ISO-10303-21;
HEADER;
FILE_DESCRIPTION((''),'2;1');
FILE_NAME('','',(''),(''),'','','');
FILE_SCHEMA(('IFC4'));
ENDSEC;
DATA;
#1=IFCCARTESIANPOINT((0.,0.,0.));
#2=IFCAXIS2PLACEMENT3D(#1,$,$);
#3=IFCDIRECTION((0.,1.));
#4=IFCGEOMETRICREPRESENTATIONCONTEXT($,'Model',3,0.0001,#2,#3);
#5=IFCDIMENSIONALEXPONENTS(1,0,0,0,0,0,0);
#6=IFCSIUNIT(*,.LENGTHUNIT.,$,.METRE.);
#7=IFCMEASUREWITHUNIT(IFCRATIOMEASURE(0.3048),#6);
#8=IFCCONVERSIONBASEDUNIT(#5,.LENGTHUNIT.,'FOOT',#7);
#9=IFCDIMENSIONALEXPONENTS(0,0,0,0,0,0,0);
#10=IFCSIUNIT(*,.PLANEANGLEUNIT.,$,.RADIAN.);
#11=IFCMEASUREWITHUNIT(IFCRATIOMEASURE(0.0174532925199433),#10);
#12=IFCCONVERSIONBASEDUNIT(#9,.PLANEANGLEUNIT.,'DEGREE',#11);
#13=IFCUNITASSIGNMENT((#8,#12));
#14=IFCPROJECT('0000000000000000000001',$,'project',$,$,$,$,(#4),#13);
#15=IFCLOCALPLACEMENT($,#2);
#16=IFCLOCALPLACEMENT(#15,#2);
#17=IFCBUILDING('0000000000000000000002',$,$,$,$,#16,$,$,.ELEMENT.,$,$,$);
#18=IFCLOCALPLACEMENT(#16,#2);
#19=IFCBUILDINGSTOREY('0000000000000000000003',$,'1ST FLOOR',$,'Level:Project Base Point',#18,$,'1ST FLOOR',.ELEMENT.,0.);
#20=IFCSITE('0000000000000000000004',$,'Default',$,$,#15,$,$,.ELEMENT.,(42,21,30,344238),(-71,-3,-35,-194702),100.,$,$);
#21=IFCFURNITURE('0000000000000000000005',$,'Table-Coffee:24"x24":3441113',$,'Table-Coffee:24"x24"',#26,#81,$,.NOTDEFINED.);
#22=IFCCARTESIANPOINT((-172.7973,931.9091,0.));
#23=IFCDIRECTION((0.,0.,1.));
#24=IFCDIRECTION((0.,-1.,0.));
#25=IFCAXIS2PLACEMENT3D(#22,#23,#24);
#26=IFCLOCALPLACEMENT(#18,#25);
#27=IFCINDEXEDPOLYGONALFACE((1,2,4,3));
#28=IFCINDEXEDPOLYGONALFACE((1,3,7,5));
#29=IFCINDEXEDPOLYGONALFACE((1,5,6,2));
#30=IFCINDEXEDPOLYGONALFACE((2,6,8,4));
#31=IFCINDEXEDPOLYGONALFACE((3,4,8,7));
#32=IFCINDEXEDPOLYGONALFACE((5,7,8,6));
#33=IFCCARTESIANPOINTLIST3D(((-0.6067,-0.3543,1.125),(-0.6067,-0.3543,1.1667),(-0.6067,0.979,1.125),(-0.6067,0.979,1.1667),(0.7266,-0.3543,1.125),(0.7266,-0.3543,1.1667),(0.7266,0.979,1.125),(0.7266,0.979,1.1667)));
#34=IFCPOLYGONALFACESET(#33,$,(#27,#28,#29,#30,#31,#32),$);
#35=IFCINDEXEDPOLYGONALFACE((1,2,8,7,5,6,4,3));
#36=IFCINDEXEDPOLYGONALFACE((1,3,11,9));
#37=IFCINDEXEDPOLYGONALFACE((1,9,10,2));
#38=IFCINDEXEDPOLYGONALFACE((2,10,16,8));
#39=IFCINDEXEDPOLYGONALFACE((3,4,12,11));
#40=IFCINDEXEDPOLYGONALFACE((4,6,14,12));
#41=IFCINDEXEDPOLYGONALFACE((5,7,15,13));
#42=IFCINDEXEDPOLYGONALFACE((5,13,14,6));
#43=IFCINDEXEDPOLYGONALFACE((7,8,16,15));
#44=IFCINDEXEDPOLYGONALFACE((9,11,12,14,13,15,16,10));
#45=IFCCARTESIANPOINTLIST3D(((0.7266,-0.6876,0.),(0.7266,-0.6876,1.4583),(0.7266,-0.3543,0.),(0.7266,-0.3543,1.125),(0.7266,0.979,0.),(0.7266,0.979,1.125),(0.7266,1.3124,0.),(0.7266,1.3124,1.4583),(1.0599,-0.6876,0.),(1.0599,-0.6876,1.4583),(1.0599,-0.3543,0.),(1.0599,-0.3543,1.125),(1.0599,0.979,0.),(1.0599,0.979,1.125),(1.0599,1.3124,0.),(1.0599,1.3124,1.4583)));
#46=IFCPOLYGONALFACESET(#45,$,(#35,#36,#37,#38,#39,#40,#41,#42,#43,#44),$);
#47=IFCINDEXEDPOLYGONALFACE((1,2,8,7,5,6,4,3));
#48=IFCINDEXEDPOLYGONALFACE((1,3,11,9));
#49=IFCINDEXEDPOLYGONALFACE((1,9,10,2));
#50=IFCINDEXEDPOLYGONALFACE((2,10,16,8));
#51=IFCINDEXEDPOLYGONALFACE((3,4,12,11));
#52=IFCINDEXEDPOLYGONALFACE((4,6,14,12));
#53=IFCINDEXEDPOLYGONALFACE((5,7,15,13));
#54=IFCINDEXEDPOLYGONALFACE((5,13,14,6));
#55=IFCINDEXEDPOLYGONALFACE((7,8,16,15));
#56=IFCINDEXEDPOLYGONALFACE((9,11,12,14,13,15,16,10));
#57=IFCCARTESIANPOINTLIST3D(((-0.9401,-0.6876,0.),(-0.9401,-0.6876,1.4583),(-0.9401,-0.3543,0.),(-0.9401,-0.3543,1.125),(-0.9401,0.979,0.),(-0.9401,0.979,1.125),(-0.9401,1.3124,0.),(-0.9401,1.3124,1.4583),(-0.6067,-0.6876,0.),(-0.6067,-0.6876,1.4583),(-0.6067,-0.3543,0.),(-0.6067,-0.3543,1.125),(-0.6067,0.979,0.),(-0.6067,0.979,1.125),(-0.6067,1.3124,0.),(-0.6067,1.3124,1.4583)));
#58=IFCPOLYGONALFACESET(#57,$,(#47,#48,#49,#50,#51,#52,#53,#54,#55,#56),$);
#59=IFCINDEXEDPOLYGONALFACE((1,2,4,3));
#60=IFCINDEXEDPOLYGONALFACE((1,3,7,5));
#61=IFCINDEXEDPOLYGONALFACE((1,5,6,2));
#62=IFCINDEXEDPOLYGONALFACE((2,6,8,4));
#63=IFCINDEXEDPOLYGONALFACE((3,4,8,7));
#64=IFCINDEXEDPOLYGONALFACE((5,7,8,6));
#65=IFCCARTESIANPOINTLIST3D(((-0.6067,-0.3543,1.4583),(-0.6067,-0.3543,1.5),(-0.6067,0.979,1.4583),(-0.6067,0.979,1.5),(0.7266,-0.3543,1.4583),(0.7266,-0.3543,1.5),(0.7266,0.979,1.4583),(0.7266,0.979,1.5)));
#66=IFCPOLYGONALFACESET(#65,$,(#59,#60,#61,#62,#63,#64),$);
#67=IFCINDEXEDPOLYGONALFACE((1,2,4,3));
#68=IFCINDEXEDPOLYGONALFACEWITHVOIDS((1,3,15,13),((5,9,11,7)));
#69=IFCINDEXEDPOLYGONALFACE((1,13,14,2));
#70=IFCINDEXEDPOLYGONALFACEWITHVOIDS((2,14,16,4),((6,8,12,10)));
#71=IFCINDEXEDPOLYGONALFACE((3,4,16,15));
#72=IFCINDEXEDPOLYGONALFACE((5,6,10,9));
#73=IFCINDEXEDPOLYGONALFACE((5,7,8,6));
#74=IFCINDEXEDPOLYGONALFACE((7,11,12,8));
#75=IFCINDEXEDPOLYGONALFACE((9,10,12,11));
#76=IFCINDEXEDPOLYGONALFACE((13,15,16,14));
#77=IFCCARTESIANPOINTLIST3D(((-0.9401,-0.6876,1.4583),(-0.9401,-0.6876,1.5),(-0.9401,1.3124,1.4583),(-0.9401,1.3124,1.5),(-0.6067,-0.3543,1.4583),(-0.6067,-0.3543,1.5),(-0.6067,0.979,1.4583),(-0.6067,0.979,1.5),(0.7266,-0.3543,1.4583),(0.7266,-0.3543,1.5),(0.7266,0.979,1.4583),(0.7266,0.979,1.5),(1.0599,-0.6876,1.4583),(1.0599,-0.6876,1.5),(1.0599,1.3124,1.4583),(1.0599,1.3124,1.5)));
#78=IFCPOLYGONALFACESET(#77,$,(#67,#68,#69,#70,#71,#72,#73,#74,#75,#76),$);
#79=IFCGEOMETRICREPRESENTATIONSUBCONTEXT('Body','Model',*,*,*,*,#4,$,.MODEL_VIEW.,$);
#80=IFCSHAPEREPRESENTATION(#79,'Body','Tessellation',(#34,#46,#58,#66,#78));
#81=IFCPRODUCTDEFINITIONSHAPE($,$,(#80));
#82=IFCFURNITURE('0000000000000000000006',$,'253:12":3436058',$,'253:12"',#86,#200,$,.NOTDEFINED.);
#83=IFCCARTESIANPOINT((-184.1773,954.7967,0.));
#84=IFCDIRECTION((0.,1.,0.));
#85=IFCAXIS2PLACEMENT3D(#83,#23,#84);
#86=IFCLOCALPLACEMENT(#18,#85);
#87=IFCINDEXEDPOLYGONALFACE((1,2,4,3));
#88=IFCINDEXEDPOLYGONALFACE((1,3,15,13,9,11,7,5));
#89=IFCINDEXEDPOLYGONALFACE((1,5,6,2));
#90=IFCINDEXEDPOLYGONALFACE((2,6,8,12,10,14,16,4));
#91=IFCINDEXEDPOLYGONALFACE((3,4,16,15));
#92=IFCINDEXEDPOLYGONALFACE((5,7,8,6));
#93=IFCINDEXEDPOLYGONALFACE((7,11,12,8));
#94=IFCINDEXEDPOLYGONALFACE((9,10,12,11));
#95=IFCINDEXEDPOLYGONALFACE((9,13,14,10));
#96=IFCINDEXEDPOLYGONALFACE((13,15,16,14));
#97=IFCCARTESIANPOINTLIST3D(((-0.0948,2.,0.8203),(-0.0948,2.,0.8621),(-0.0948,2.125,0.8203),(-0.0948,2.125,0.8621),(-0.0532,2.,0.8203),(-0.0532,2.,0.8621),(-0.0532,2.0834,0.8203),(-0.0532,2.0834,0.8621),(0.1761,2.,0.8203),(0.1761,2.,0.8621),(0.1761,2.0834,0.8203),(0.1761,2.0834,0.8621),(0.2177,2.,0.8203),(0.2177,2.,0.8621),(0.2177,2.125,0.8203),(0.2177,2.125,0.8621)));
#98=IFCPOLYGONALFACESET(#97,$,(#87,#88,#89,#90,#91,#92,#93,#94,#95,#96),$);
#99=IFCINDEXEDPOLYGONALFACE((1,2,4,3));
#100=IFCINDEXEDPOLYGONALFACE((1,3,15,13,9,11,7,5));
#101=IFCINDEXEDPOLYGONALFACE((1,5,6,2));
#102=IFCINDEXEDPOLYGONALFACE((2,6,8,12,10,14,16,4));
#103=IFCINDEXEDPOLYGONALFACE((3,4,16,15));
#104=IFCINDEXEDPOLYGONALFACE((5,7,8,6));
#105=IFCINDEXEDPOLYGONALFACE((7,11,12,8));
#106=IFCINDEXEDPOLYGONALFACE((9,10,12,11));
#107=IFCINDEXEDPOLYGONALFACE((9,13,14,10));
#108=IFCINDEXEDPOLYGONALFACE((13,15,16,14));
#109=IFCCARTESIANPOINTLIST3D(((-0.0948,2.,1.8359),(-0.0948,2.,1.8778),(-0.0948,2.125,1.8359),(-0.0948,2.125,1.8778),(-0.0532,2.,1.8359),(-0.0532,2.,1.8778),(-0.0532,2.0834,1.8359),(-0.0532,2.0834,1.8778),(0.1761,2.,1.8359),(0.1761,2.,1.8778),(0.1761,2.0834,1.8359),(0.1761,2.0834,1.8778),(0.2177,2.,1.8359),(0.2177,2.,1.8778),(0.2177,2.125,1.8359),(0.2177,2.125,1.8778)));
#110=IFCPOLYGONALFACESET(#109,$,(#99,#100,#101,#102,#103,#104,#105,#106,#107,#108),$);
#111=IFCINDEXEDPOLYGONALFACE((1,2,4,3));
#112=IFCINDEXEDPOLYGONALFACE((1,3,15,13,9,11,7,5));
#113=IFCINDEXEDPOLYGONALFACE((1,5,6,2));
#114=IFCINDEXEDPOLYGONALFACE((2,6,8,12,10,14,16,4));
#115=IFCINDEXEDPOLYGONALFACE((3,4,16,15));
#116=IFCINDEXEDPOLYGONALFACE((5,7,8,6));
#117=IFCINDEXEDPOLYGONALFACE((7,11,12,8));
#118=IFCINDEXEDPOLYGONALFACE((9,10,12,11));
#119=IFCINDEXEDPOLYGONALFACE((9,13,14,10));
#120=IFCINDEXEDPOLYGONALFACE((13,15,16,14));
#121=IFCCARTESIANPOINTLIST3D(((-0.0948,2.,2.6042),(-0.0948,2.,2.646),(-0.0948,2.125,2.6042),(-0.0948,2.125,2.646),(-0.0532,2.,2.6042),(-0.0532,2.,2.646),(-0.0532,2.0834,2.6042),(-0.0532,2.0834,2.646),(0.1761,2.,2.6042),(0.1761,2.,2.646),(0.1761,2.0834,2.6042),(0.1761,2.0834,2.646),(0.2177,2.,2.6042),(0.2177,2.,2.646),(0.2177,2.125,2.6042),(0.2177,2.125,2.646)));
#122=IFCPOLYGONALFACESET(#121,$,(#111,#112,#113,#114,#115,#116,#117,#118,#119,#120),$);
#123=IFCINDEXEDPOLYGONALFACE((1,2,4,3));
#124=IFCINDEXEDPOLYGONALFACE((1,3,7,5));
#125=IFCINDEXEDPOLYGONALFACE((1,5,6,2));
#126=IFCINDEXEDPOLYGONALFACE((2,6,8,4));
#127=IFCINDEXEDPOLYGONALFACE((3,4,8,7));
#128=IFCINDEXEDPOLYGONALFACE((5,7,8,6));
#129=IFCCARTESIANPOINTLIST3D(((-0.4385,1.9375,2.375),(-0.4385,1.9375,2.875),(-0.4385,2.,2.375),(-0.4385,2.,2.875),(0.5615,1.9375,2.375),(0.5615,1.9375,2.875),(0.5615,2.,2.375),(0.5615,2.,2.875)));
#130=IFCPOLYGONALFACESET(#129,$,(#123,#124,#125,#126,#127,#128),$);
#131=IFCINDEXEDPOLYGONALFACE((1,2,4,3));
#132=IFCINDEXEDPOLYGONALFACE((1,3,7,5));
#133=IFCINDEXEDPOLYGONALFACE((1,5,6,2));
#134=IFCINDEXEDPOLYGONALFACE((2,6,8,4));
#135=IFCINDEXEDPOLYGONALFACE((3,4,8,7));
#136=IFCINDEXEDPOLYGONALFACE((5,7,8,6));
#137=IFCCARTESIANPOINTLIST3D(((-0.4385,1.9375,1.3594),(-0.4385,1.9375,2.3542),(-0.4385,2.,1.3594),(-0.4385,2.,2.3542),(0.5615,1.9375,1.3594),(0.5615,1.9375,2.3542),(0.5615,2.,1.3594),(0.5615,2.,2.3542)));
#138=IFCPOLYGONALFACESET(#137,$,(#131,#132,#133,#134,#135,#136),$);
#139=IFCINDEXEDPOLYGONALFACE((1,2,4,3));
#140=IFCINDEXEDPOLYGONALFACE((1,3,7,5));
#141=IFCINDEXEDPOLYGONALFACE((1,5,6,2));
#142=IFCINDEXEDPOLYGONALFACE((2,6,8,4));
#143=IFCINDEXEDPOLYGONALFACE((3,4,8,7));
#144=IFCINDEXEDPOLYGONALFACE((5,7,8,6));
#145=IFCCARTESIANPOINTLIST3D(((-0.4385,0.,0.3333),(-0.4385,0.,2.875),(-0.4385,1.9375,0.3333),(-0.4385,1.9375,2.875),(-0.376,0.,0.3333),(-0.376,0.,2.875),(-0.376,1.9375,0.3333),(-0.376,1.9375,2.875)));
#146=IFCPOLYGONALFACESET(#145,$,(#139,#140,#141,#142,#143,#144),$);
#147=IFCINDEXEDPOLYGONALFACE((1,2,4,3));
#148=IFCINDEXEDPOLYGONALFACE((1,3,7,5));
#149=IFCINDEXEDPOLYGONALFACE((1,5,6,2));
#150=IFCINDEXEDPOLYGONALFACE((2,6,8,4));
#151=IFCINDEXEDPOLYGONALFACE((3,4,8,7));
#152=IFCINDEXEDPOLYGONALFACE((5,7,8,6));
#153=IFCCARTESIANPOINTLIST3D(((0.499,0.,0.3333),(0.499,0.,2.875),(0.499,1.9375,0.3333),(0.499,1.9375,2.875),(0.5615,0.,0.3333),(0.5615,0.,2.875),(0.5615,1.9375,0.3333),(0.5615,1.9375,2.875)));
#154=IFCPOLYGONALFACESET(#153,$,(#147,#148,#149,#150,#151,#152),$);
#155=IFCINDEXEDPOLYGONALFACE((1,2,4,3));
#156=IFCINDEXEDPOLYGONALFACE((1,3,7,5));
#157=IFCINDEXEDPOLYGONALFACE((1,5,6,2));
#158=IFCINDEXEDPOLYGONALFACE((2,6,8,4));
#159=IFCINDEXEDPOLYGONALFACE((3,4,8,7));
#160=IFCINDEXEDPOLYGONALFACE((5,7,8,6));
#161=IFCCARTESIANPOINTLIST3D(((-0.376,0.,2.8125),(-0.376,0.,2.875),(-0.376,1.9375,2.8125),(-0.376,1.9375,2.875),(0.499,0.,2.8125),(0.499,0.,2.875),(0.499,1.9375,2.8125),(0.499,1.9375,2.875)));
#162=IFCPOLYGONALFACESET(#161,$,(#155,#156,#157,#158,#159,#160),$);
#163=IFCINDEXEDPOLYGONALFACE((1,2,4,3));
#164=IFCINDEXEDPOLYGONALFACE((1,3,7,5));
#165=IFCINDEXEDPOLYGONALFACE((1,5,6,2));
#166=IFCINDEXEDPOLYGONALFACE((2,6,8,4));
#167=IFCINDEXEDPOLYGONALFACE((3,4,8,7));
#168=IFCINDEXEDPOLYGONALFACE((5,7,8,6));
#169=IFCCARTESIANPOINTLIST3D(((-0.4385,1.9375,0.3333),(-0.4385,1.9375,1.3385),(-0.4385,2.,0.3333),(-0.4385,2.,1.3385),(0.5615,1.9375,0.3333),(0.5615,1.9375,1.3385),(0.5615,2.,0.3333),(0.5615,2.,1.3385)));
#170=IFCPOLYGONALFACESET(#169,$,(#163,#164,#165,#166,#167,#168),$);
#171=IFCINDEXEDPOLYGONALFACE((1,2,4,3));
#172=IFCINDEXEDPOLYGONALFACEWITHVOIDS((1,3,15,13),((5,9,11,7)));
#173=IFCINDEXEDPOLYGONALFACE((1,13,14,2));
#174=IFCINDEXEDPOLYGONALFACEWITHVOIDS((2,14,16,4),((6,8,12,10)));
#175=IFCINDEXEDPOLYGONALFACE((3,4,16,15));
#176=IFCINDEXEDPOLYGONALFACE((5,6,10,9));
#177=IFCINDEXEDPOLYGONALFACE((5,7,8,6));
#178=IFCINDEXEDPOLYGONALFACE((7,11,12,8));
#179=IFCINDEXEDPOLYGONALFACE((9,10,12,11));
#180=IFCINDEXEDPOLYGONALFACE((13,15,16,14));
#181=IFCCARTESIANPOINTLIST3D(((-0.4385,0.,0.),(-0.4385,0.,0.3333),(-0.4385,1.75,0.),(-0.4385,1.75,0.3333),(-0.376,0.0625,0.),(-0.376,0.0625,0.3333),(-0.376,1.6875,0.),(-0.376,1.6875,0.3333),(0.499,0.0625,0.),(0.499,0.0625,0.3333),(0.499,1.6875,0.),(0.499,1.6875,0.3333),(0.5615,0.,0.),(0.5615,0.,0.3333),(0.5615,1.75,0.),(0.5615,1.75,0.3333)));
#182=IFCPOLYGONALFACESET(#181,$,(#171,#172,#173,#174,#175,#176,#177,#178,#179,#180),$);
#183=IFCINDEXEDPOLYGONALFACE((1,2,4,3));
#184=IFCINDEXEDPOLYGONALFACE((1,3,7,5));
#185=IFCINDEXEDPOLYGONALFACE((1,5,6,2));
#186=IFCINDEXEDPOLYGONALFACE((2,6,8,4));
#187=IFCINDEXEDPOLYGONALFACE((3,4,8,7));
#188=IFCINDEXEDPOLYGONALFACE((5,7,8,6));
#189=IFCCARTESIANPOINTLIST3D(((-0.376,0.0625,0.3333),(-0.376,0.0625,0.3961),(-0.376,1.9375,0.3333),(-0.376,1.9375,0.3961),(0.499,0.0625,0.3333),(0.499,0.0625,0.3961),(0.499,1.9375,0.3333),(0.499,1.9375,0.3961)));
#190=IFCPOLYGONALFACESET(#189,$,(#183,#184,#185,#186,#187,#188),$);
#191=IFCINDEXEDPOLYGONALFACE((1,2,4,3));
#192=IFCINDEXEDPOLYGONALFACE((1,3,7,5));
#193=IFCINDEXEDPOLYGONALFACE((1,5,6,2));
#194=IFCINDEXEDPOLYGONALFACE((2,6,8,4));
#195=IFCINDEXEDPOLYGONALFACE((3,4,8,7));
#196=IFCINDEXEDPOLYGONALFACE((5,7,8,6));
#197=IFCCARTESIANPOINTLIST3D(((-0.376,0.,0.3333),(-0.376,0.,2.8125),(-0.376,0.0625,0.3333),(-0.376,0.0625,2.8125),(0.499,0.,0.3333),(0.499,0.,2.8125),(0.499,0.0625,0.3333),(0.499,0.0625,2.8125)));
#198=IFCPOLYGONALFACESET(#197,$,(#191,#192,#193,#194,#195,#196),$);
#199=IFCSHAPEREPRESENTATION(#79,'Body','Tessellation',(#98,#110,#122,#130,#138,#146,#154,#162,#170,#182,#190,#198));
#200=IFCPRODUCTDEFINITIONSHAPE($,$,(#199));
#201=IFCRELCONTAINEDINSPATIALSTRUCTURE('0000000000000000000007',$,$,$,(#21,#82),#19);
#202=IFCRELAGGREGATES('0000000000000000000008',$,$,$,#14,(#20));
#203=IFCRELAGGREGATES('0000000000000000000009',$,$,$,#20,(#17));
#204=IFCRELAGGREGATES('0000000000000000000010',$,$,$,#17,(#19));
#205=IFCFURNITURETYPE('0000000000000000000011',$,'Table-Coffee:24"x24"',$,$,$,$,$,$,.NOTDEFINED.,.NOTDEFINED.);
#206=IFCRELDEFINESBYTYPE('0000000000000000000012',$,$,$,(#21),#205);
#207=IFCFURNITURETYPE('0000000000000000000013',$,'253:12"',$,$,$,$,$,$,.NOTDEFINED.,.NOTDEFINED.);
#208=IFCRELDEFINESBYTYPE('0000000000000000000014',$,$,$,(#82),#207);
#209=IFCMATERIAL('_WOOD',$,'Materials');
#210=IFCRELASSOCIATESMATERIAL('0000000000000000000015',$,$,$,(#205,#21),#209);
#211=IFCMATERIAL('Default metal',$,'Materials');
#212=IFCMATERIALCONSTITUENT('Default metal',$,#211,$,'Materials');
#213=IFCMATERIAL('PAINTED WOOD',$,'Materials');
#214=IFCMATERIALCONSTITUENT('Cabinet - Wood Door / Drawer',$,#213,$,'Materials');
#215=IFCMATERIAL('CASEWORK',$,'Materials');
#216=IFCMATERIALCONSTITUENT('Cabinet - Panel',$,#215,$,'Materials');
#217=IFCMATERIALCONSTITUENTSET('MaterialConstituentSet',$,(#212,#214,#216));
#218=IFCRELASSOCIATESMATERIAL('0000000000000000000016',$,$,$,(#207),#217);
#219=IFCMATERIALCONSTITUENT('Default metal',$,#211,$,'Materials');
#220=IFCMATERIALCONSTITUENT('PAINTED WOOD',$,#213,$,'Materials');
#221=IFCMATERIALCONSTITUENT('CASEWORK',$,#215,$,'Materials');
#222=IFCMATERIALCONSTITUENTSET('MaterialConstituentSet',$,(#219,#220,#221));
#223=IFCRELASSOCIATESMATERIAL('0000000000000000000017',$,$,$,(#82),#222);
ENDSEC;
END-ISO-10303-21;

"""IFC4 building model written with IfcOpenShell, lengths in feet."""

from ifc_helpers import new_model, entity, si_unit, converted_unit, direction, frame, frame_2d, origin, origin_2d_with_axis, place, context, subcontext, project, spatial, polyline, rectangle, outline, extrude, source, transform, mapped, material, constituent, constituent_set, type_object, type_shapes, element, save


model = new_model("IFC4")

# Units and contexts
model_context = context("Model", 3, precision=0.0001, world=origin(), true_north=direction((0.0, 1.0)))
body_context = subcontext(model_context, "Body", "Model", "MODEL_VIEW")
ifc_project = project(units=[converted_unit("LENGTHUNIT", "FOOT", entity("IfcRatioMeasure", 0.3048), si_unit("LENGTHUNIT", "METRE"), dimensions=[1, 0, 0, 0, 0, 0, 0]), converted_unit("PLANEANGLEUNIT", "DEGREE", entity("IfcRatioMeasure", 0.0174532925199433), si_unit("PLANEANGLEUNIT", "RADIAN"), dimensions=[0, 0, 0, 0, 0, 0, 0])], contexts=[model_context])

# Site, building, storey
site_placement = place(None, origin())
site = spatial("IfcSite", under=ifc_project, at=site_placement, Name="Default", CompositionType="ELEMENT", RefLatitude=(42, 21, 30, 344238), RefLongitude=(-71, -3, -35, -194702), RefElevation=100.0)
building_placement = place(site_placement, origin())
building = spatial("IfcBuilding", under=site, at=building_placement, CompositionType="ELEMENT")
storey_placement = place(building_placement, origin())
storey = spatial("IfcBuildingStorey", under=building, at=storey_placement, Name="1ST FLOOR", ObjectType="Level:Project Base Point", LongName="1ST FLOOR", CompositionType="ELEMENT", Elevation=0.0)

# Furniture
ifc_material_1 = material(Name="_WOOD", Category="Materials")
furniture_type_1 = type_object("IfcFurnitureType", Name="Table-Coffee:24\"x24\"", AssemblyPlace="NOTDEFINED", PredefinedType="NOTDEFINED", material=ifc_material_1)
shared_shape_1 = source(origin(), body_context, "Body", "SweptSolid", [
    extrude(rectangle(XDim=1.3333, YDim=1.3333, at=origin_2d_with_axis()), frame((0.0599, 0.3124, 1.125), z_axis=(0.0, 0.0, 1.0), x_axis=(-1.0, 0.0, 0.0)), (0.0, 0.0, 1.0), 0.0417),
    extrude(outline(polyline([(-0.6458, -1.0), (0.8125, -1.0), (0.8125, 1.0), (-0.6458, 1.0), (-0.6458, 0.6667), (0.4792, 0.6667), (0.4792, -0.6667), (-0.6458, -0.6667), (-0.6458, -1.0)])), frame((0.7266, 0.3124, 0.6458), z_axis=(1.0, 0.0, 0.0), x_axis=(0.0, 0.0, 1.0)), (0.0, 0.0, 1.0), 0.3333),
    extrude(outline(polyline([(-1.0, -0.8125), (1.0, -0.8125), (1.0, 0.6458), (0.6667, 0.6458), (0.6667, -0.4792), (-0.6667, -0.4792), (-0.6667, 0.6458), (-1.0, 0.6458), (-1.0, -0.8125)])), frame((-0.9401, 0.3124, 0.6458), z_axis=(1.0, 0.0, 0.0), x_axis=(0.0, -1.0, 0.0)), (0.0, 0.0, 1.0), 0.3333),
    extrude(rectangle(XDim=1.3333, YDim=1.3333, at=origin_2d_with_axis()), frame((0.0599, 0.3124, 1.4583), z_axis=(0.0, 0.0, 1.0), x_axis=(-1.0, 0.0, 0.0)), (0.0, 0.0, 1.0), 0.0417),
    extrude(outline(polyline([(-1.0, -1.0), (1.0, -1.0), (1.0, 1.0), (-1.0, 1.0), (-1.0, -1.0)]), holes=[polyline([(-0.6667, -0.6667), (-0.6667, 0.6667), (0.6667, 0.6667), (0.6667, -0.6667), (-0.6667, -0.6667)])]), frame((0.0599, 0.3124, 1.4583), z_axis=(0.0, 0.0, 1.0), x_axis=(-1.0, 0.0, 0.0)), (0.0, 0.0, 1.0), 0.0417),
])
type_shapes(furniture_type_1, [shared_shape_1])
furniture_1_placement = place(storey_placement, frame((-172.7973, 931.9091, 0.0), z_axis=(0.0, 0.0, 1.0), x_axis=(0.0, -1.0, 0.0)))
element("IfcFurniture", 1, at=furniture_1_placement, inside=storey, type_object=furniture_type_1, material=ifc_material_1, Name="Table-Coffee:24\"x24\":3441113", ObjectType="Table-Coffee:24\"x24\"", PredefinedType="NOTDEFINED", context=body_context, shape_type="MappedRepresentation", body=[
    mapped(shared_shape_1, transform((0.0, 0.0, 0.0), scale=1.0)),
])
ifc_material_2 = material(Name="CASEWORK", Category="Materials")

# Furniture
ifc_material_3 = material(Name="Default metal", Category="Materials")
ifc_constituent_1 = constituent(ifc_material_3, Name="Default metal", Category="Materials")
ifc_material_4 = material(Name="PAINTED WOOD", Category="Materials")
ifc_constituent_2 = constituent(ifc_material_4, Name="PAINTED WOOD", Category="Materials")
ifc_constituent_3 = constituent(ifc_material_2, Name="CASEWORK", Category="Materials")
ifc_constituent_set_1 = constituent_set(constituents=[ifc_constituent_1, ifc_constituent_2, ifc_constituent_3], Name="MaterialConstituentSet")
ifc_constituent_4 = constituent(ifc_material_3, Name="Default metal", Category="Materials")
ifc_constituent_5 = constituent(ifc_material_4, Name="Cabinet - Wood Door / Drawer", Category="Materials")
ifc_constituent_6 = constituent(ifc_material_2, Name="Cabinet - Panel", Category="Materials")
ifc_constituent_set_2 = constituent_set(constituents=[ifc_constituent_4, ifc_constituent_5, ifc_constituent_6], Name="MaterialConstituentSet")
furniture_type_2 = type_object("IfcFurnitureType", Name="253:12\"", AssemblyPlace="NOTDEFINED", PredefinedType="NOTDEFINED", material=ifc_constituent_set_2)
shared_shape_2 = source(origin(), body_context, "Body", "SweptSolid", [
    extrude(outline(polyline([(-0.1562, -0.0521), (-0.1146, -0.0521), (-0.1146, 0.0313), (0.1146, 0.0313), (0.1146, -0.0521), (0.1562, -0.0521), (0.1562, 0.0729), (-0.1562, 0.0729), (-0.1562, -0.0521)])), frame((0.0615, 2.0521, 0.8203)), (0.0, 0.0, 1.0), 0.0418),
    extrude(outline(polyline([(-0.1562, -0.0521), (-0.1146, -0.0521), (-0.1146, 0.0313), (0.1146, 0.0313), (0.1146, -0.0521), (0.1562, -0.0521), (0.1562, 0.0729), (-0.1562, 0.0729), (-0.1562, -0.0521)])), frame((0.0615, 2.0521, 1.8359)), (0.0, 0.0, 1.0), 0.0418),
    extrude(outline(polyline([(-0.1562, -0.0521), (-0.1146, -0.0521), (-0.1146, 0.0313), (0.1146, 0.0313), (0.1146, -0.0521), (0.1562, -0.0521), (0.1562, 0.0729), (-0.1562, 0.0729), (-0.1562, -0.0521)])), frame((0.0615, 2.0521, 2.6042)), (0.0, 0.0, 1.0), 0.0418),
    extrude(rectangle(XDim=1.0, YDim=0.0625, at=frame_2d((0.0, 0.0), x_axis=(1.0, 0.0))), frame((0.0615, 1.9688, 2.375), z_axis=(0.0, 0.0, 1.0), x_axis=(-1.0, 0.0, 0.0)), (0.0, 0.0, 1.0), 0.5),
    extrude(rectangle(XDim=1.0, YDim=0.0625, at=frame_2d((0.0, 0.0), x_axis=(1.0, 0.0))), frame((0.0615, 1.9688, 1.3594), z_axis=(0.0, 0.0, 1.0), x_axis=(-1.0, 0.0, 0.0)), (0.0, 0.0, 1.0), 0.9948),
    extrude(rectangle(XDim=1.9375, YDim=0.0625, at=frame_2d((0.0, 0.0), x_axis=(1.0, 0.0))), frame((-0.4073, 0.9687, 0.3333), z_axis=(0.0, 0.0, 1.0), x_axis=(0.0, -1.0, 0.0)), (0.0, 0.0, 1.0), 2.5417),
    extrude(rectangle(XDim=1.9375, YDim=0.0625, at=frame_2d((0.0, 0.0), x_axis=(1.0, 0.0))), frame((0.5302, 0.9687, 0.3333), z_axis=(0.0, 0.0, 1.0), x_axis=(0.0, -1.0, 0.0)), (0.0, 0.0, 1.0), 2.5417),
    extrude(rectangle(XDim=1.9375, YDim=0.875, at=origin_2d_with_axis()), frame((0.0615, 0.9688, 2.8125), z_axis=(0.0, 0.0, 1.0), x_axis=(0.0, 1.0, 0.0)), (0.0, 0.0, 1.0), 0.0625),
    extrude(rectangle(XDim=1.0, YDim=0.0625, at=frame_2d((0.0, 0.0), x_axis=(1.0, 0.0))), frame((0.0615, 1.9688, 0.3333), z_axis=(0.0, 0.0, 1.0), x_axis=(-1.0, 0.0, 0.0)), (0.0, 0.0, 1.0), 1.0052),
    extrude(outline(polyline([(-0.875, -0.5), (0.875, -0.5), (0.875, 0.5), (-0.875, 0.5), (-0.875, -0.5)]), holes=[polyline([(-0.8125, -0.4375), (-0.8125, 0.4375), (0.8125, 0.4375), (0.8125, -0.4375), (-0.8125, -0.4375)])]), frame((0.0615, 0.875, 0.0), z_axis=(0.0, 0.0, 1.0), x_axis=(0.0, -1.0, 0.0)), (0.0, 0.0, 1.0), 0.3333),
    extrude(rectangle(XDim=1.875, YDim=0.875, at=origin_2d_with_axis()), frame((0.0615, 1.0, 0.3333), z_axis=(0.0, 0.0, 1.0), x_axis=(0.0, 1.0, 0.0)), (0.0, 0.0, 1.0), 0.0627),
    extrude(rectangle(XDim=0.875, YDim=0.0625, at=origin_2d_with_axis()), frame((0.0615, 0.0312, 0.3333), z_axis=(0.0, 0.0, 1.0), x_axis=(-1.0, 0.0, 0.0)), (0.0, 0.0, 1.0), 2.4792),
])
type_shapes(furniture_type_2, [shared_shape_2])
furniture_2_placement = place(storey_placement, frame((-184.1773, 954.7967, 0.0), z_axis=(0.0, 0.0, 1.0), x_axis=(0.0, 1.0, 0.0)))
element("IfcFurniture", 2, at=furniture_2_placement, inside=storey, type_object=furniture_type_2, material=ifc_constituent_set_1, Name="253:12\":3436058", ObjectType="253:12\"", PredefinedType="NOTDEFINED", context=body_context, shape_type="MappedRepresentation", body=[
    mapped(shared_shape_2, transform((0.0, 0.0, 0.0), scale=1.0)),
])

save(model, "model.ifc")
